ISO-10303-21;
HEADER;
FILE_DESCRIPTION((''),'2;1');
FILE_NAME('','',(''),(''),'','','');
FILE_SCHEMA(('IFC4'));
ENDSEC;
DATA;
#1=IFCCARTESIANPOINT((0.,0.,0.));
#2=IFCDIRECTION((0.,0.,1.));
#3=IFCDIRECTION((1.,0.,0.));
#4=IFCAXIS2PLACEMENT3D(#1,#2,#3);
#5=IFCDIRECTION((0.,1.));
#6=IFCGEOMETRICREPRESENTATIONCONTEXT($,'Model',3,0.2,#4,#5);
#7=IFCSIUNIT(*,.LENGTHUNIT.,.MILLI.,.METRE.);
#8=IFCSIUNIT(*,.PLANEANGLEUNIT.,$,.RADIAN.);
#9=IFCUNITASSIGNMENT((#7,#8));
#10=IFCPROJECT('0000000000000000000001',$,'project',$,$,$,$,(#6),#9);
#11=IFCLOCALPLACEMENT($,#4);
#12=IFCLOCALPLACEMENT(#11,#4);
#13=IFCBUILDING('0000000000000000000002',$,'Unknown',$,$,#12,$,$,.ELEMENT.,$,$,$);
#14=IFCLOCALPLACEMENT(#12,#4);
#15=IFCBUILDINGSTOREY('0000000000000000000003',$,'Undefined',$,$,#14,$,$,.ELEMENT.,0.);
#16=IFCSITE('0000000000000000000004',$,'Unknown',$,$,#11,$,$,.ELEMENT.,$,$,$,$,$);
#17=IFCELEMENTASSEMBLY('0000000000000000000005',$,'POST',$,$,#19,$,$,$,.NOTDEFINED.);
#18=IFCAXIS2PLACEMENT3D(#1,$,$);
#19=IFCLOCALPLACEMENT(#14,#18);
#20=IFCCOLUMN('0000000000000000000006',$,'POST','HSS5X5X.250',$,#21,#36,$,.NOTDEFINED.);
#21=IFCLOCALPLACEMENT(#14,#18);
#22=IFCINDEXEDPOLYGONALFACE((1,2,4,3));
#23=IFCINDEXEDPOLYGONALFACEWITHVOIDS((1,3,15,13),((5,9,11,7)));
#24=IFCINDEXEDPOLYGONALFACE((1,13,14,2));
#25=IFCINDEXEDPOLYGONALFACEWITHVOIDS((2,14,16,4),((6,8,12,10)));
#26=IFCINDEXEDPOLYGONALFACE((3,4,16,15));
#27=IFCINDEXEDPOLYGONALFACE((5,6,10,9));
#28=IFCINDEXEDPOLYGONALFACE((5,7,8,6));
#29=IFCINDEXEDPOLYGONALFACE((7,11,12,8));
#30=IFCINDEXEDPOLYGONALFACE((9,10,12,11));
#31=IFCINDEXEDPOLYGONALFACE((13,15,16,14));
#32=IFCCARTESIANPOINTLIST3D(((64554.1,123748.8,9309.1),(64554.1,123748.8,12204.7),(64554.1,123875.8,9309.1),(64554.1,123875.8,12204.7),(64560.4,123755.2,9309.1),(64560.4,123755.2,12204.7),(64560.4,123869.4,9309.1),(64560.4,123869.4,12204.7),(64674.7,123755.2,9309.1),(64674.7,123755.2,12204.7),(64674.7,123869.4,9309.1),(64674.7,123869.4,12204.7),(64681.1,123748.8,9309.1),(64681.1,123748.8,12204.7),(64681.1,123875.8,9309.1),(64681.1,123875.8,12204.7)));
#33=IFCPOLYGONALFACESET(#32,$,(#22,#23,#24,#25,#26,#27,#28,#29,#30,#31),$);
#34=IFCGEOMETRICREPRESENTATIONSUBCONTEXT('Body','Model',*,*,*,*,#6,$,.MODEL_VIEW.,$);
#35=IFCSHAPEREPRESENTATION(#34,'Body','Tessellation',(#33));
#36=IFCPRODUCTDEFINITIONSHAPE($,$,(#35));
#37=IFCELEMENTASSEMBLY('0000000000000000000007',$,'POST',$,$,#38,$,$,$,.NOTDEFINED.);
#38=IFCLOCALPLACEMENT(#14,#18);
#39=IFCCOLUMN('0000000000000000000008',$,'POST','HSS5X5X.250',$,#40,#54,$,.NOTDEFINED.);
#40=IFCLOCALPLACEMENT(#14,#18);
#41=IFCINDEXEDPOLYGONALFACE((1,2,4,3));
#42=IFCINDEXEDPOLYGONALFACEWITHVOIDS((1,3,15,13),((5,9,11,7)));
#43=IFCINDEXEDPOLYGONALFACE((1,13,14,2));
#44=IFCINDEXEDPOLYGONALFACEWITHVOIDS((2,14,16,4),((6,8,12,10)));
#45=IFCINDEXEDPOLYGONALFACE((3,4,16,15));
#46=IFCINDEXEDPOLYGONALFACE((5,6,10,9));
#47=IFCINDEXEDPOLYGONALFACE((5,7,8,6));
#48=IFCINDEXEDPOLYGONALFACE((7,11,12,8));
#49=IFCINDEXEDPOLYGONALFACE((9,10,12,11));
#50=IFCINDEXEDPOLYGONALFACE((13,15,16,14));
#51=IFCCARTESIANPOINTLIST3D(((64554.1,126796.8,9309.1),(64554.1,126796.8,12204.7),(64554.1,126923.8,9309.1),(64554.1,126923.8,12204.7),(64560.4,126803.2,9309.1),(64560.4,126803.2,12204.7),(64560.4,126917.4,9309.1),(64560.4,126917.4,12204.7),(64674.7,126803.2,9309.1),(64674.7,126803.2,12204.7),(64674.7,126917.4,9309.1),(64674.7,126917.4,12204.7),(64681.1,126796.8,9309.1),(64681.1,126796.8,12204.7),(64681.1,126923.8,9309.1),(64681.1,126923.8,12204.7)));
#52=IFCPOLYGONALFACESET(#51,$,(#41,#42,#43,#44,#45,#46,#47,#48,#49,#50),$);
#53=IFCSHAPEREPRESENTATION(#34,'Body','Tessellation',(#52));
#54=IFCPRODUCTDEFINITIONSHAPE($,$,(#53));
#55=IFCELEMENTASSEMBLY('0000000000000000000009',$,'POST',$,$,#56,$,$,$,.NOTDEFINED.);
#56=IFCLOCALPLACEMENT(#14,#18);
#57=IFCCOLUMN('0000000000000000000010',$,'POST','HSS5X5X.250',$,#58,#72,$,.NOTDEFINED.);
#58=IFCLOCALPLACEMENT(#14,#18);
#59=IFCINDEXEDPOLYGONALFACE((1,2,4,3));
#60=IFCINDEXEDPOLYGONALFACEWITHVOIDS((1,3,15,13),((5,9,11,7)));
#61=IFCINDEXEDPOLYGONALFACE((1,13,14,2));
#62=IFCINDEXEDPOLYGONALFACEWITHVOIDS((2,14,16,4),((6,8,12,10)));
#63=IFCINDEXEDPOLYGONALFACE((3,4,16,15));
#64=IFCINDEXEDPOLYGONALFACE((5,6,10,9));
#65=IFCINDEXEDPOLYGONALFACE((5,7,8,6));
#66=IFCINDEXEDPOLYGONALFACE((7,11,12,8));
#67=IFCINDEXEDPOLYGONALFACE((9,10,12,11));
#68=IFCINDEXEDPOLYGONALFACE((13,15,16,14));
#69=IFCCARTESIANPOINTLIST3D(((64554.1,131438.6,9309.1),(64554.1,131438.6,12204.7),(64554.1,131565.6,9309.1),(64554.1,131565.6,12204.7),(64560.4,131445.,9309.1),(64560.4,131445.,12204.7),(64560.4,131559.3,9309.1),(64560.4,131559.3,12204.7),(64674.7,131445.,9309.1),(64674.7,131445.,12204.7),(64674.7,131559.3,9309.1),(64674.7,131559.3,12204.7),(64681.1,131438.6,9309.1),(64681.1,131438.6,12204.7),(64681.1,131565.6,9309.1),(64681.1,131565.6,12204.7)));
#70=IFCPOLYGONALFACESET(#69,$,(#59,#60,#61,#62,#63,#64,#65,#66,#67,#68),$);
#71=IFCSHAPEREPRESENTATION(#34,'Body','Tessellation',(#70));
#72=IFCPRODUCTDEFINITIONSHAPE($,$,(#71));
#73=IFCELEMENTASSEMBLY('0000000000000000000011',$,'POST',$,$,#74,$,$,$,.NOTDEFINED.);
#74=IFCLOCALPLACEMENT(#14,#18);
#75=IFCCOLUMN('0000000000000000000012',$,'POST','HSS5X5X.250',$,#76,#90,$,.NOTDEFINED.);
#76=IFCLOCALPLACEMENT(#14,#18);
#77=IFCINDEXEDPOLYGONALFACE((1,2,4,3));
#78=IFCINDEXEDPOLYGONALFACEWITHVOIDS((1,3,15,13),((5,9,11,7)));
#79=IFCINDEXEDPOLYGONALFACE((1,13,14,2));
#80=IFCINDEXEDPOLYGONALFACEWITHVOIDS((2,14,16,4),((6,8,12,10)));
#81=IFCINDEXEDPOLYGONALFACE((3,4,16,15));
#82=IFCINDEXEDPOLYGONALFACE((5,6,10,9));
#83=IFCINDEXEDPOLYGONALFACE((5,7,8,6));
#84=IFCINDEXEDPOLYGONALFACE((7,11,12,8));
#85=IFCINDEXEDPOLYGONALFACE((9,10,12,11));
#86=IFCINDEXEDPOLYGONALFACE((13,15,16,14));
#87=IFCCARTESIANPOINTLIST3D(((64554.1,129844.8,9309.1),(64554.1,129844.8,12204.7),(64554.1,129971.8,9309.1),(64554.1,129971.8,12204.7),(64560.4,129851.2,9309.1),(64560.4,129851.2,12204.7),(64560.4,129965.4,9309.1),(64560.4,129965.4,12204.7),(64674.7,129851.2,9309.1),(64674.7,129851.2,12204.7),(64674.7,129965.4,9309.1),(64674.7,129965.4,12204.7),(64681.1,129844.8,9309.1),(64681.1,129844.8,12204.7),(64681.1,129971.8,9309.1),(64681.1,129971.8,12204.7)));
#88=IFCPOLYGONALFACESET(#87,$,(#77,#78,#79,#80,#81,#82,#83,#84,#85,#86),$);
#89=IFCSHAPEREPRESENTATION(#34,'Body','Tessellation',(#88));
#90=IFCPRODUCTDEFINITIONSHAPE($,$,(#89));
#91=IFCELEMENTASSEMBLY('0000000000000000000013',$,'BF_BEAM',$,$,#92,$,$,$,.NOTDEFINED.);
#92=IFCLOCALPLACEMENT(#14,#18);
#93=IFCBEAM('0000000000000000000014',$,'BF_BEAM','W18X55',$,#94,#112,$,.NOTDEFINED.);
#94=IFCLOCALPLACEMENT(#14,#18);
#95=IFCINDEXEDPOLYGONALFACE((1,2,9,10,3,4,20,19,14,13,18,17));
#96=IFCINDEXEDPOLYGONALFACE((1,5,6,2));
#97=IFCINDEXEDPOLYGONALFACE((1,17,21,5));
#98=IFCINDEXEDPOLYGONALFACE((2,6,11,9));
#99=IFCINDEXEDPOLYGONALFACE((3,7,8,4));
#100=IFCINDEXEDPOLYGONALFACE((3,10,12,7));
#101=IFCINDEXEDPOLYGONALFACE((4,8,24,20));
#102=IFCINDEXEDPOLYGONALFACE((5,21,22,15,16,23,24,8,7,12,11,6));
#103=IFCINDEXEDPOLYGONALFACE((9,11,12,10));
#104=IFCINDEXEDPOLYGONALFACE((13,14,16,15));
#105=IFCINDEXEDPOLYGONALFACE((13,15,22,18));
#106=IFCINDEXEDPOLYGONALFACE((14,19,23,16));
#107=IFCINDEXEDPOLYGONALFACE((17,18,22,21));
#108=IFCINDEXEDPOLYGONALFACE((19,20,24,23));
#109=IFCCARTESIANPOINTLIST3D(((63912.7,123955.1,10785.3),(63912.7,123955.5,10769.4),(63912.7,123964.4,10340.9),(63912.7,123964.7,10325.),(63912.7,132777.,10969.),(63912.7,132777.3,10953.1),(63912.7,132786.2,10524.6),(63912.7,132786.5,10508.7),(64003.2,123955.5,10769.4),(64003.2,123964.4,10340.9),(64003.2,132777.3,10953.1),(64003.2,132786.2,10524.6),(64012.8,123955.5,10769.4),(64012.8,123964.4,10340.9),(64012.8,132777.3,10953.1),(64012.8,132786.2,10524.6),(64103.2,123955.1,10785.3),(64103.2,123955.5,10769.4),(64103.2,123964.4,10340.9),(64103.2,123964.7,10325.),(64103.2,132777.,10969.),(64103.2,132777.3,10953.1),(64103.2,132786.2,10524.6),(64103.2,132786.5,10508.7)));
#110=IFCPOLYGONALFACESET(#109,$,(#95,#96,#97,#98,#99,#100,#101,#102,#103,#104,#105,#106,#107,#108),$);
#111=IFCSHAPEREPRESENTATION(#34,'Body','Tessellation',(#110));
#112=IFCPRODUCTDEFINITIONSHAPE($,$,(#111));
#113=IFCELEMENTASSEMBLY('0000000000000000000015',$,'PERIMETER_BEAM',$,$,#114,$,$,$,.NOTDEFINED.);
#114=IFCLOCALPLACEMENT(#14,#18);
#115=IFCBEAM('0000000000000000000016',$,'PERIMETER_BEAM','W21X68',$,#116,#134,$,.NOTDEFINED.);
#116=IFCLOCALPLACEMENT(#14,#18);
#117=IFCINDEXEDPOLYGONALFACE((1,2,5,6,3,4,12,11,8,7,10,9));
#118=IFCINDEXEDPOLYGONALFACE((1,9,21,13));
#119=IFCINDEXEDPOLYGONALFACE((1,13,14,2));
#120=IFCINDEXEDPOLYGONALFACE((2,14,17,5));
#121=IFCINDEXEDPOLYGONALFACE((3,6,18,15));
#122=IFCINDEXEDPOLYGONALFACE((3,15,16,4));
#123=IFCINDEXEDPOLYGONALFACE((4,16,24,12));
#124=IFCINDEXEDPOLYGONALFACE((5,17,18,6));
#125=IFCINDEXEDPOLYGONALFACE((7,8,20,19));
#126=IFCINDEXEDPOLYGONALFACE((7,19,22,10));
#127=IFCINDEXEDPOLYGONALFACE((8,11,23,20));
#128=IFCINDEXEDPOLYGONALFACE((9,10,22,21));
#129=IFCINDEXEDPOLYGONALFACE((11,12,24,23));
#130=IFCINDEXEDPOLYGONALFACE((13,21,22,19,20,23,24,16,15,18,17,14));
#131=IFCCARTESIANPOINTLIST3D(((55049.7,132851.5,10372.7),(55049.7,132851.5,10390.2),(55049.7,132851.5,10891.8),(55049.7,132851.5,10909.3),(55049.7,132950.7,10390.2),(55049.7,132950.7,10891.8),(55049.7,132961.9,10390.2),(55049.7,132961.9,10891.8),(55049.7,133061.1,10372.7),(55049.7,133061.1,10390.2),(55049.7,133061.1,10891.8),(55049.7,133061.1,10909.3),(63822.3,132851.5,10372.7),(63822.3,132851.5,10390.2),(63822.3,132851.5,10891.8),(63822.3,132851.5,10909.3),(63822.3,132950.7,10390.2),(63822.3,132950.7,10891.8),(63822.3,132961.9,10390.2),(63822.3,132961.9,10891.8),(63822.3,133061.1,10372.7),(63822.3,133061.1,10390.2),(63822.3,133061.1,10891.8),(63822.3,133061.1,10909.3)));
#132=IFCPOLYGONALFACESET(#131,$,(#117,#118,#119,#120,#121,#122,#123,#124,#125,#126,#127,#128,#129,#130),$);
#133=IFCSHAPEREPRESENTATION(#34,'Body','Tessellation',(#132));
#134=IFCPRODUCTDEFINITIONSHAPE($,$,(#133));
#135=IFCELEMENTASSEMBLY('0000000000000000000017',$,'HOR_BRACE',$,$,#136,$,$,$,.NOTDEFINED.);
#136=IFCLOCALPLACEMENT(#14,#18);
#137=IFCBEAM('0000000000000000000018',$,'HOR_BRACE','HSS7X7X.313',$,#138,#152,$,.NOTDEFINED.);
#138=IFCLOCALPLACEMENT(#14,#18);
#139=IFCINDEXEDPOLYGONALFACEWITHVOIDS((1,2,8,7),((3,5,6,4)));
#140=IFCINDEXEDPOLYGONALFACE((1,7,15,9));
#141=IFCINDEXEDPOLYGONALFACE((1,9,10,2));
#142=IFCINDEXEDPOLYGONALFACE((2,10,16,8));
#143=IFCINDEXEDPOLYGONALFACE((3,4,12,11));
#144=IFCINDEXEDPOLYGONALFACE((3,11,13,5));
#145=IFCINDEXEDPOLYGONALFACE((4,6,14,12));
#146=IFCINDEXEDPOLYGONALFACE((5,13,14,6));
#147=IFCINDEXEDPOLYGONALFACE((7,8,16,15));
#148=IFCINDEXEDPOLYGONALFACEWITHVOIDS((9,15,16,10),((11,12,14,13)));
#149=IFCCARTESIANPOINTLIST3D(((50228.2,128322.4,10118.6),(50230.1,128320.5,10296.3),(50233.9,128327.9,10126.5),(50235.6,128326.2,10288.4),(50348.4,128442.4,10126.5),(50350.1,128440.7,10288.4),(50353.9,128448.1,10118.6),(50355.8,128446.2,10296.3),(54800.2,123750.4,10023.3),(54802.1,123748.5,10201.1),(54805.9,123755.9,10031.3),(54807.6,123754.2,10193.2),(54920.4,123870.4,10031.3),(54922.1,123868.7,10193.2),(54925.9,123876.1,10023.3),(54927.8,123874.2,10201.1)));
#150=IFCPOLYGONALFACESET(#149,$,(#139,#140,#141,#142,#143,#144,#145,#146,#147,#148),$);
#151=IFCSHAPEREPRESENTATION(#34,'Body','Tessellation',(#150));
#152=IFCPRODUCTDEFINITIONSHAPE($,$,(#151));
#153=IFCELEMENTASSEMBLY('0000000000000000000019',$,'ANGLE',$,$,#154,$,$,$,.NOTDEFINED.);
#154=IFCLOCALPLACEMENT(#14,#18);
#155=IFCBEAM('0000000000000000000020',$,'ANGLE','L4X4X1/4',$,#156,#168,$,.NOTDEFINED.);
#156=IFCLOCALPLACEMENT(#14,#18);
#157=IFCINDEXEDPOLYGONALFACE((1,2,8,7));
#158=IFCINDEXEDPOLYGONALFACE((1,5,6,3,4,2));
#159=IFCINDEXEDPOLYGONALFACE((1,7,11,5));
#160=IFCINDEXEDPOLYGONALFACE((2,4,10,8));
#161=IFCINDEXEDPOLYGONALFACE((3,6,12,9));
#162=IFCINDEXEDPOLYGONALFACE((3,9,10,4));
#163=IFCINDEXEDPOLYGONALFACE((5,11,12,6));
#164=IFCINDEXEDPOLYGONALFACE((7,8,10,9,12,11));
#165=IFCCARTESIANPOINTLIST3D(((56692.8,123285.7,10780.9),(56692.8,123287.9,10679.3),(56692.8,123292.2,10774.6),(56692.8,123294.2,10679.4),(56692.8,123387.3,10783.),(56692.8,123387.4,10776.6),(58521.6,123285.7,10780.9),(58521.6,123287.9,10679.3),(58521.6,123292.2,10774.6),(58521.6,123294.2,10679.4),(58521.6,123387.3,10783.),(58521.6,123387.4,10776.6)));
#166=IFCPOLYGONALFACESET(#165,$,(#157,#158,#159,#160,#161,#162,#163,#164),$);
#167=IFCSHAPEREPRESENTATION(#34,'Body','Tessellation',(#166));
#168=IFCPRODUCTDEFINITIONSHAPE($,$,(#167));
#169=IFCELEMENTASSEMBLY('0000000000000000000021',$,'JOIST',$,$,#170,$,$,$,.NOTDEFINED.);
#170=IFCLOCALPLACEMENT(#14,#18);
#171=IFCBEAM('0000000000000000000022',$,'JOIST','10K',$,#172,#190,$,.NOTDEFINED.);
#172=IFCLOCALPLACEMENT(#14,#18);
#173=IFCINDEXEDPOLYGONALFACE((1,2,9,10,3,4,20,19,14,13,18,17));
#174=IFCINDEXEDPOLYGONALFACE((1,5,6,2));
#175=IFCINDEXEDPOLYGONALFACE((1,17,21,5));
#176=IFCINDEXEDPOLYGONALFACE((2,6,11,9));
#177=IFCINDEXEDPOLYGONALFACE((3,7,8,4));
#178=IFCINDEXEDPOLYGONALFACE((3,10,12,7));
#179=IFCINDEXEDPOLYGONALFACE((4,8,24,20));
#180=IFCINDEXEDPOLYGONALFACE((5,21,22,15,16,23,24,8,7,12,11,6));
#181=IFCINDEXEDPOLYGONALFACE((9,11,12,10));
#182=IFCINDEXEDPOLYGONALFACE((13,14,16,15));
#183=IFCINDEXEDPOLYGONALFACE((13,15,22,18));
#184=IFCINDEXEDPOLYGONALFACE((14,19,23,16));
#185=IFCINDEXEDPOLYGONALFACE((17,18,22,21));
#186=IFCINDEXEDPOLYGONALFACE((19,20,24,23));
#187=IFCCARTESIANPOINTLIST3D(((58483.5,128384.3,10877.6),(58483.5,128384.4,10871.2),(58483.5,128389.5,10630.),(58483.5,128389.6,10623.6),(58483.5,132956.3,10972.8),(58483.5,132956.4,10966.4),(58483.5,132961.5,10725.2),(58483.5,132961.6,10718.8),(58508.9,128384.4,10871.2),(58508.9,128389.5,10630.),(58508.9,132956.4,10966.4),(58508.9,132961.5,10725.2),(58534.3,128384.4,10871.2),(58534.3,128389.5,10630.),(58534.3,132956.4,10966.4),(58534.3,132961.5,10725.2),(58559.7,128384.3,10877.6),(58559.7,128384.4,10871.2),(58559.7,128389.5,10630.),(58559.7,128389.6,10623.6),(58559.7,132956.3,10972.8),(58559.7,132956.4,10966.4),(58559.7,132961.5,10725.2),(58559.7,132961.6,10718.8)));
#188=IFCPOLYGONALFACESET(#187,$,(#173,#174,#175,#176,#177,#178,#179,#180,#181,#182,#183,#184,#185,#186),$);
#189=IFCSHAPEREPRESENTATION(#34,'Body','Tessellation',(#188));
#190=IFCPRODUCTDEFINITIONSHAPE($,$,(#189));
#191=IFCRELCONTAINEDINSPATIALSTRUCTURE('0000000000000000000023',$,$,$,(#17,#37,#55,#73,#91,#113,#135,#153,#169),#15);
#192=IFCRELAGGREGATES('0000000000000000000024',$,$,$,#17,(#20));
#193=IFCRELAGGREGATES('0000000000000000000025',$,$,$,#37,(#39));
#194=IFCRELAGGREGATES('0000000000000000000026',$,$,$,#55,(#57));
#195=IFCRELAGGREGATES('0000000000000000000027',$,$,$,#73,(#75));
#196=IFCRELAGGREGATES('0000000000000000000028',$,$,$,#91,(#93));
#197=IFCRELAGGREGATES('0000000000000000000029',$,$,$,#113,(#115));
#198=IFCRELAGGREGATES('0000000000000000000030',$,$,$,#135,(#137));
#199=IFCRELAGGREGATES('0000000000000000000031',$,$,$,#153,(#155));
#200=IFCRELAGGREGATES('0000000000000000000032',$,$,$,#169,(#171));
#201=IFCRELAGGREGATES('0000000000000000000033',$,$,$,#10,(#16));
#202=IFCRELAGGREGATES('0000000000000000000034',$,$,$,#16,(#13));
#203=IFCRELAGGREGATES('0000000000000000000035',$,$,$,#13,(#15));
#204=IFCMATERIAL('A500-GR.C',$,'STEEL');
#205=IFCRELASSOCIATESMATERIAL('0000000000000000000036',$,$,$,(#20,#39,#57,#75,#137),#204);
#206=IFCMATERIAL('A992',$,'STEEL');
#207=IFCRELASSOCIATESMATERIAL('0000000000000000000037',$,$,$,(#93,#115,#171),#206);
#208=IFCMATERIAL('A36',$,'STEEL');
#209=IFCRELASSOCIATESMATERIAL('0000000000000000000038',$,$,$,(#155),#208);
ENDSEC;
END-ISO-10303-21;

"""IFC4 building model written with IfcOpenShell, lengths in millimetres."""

from ifc_helpers import new_model, si_unit, direction, frame, origin_with_axes, place, context, subcontext, project, spatial, line, indexed_curve, outline, extrude, material, element, aggregate, save


model = new_model("IFC4")

# Units and contexts
model_context = context("Model", 3, precision=0.2, world=origin_with_axes(), true_north=direction((0.0, 1.0)))
body_context = subcontext(model_context, "Body", "Model", "MODEL_VIEW")
ifc_project = project(units=[si_unit("LENGTHUNIT", "METRE", prefix="MILLI"), si_unit("PLANEANGLEUNIT", "RADIAN")], contexts=[model_context])

# Site, building, storey
site_placement = place(None, origin_with_axes())
site = spatial("IfcSite", under=ifc_project, at=site_placement, Name="Unknown", CompositionType="ELEMENT")
building_placement = place(site_placement, origin_with_axes())
building = spatial("IfcBuilding", under=site, at=building_placement, Name="Unknown", CompositionType="ELEMENT")
storey_placement = place(building_placement, origin_with_axes())
storey = spatial("IfcBuildingStorey", under=building, at=storey_placement, Name="Undefined", CompositionType="ELEMENT", Elevation=0.0)

# Element assemblies, columns
assembly_1_placement = place(storey_placement, frame((64617.6, 123812.3, 9309.1), z_axis=(0.0, -1.0, 0.0), x_axis=(0.0, 0.0, 1.0)))
assembly_1 = element("IfcElementAssembly", 1, at=assembly_1_placement, inside=storey, Name="POST", PredefinedType="NOTDEFINED")
ifc_material_1 = material(Name="A500-GR.C", Category="STEEL")
column_1_placement = place(assembly_1_placement, origin_with_axes())
column_1 = element("IfcColumn", 2, at=column_1_placement, material=ifc_material_1, Name="POST", Description="HSS5X5X.250", PredefinedType="NOTDEFINED", context=body_context, shape_type="SolidModel", body=[
    extrude(outline(indexed_curve([(-63.5, -63.5), (63.5, -63.5), (63.5, 63.5), (-63.5, 63.5)], segments=[line(1, 2, 3, 4, 1)]), holes=[indexed_curve([(-57.1, -57.1), (-57.1, 57.1), (57.1, 57.1), (57.1, -57.1)], segments=[line(1, 2, 3, 4, 1)])]), frame((0.0, 0.0, 0.0), z_axis=(-1.0, 0.0, 0.0), x_axis=(0.0, 0.0, 1.0)), (0.0, 0.0, -1.0), 2895.6),
])
aggregate(assembly_1, [column_1])
assembly_2_placement = place(storey_placement, frame((64617.6, 126860.3, 9309.1), z_axis=(0.0, -1.0, 0.0), x_axis=(0.0, 0.0, 1.0)))
assembly_2 = element("IfcElementAssembly", 3, at=assembly_2_placement, inside=storey, Name="POST", PredefinedType="NOTDEFINED")
column_2_placement = place(assembly_2_placement, origin_with_axes())
column_2 = element("IfcColumn", 4, at=column_2_placement, material=ifc_material_1, Name="POST", Description="HSS5X5X.250", PredefinedType="NOTDEFINED", context=body_context, shape_type="SolidModel", body=[
    extrude(outline(indexed_curve([(-63.5, -63.5), (63.5, -63.5), (63.5, 63.5), (-63.5, 63.5)], segments=[line(1, 2, 3, 4, 1)]), holes=[indexed_curve([(-57.1, -57.1), (-57.1, 57.1), (57.1, 57.1), (57.1, -57.1)], segments=[line(1, 2, 3, 4, 1)])]), frame((0.0, 0.0, 0.0), z_axis=(-1.0, 0.0, 0.0), x_axis=(0.0, 0.0, 1.0)), (0.0, 0.0, -1.0), 2895.6),
])
aggregate(assembly_2, [column_2])
assembly_3_placement = place(storey_placement, frame((64617.6, 131502.1, 9309.1), z_axis=(0.0, -1.0, 0.0), x_axis=(0.0, 0.0, 1.0)))
assembly_3 = element("IfcElementAssembly", 5, at=assembly_3_placement, inside=storey, Name="POST", PredefinedType="NOTDEFINED")
column_3_placement = place(assembly_3_placement, origin_with_axes())
column_3 = element("IfcColumn", 6, at=column_3_placement, material=ifc_material_1, Name="POST", Description="HSS5X5X.250", PredefinedType="NOTDEFINED", context=body_context, shape_type="SolidModel", body=[
    extrude(outline(indexed_curve([(-63.5, -63.5), (63.5, -63.5), (63.5, 63.5), (-63.5, 63.5)], segments=[line(1, 2, 3, 4, 1)]), holes=[indexed_curve([(-57.1, -57.1), (-57.1, 57.1), (57.1, 57.1), (57.1, -57.1)], segments=[line(1, 2, 3, 4, 1)])]), frame((0.0, 0.0, 0.0), z_axis=(-1.0, 0.0, 0.0), x_axis=(0.0, 0.0, 1.0)), (0.0, 0.0, -1.0), 2895.6),
])
aggregate(assembly_3, [column_3])
assembly_4_placement = place(storey_placement, frame((64617.6, 129908.3, 9309.1), z_axis=(0.0, -1.0, 0.0), x_axis=(0.0, 0.0, 1.0)))
assembly_4 = element("IfcElementAssembly", 7, at=assembly_4_placement, inside=storey, Name="POST", PredefinedType="NOTDEFINED")
column_4_placement = place(assembly_4_placement, origin_with_axes())
column_4 = element("IfcColumn", 8, at=column_4_placement, material=ifc_material_1, Name="POST", Description="HSS5X5X.250", PredefinedType="NOTDEFINED", context=body_context, shape_type="SolidModel", body=[
    extrude(outline(indexed_curve([(-63.5, -63.5), (63.5, -63.5), (63.5, 63.5), (-63.5, 63.5)], segments=[line(1, 2, 3, 4, 1)]), holes=[indexed_curve([(-57.1, -57.1), (-57.1, 57.1), (57.1, 57.1), (57.1, -57.1)], segments=[line(1, 2, 3, 4, 1)])]), frame((0.0, 0.0, 0.0), z_axis=(-1.0, 0.0, 0.0), x_axis=(0.0, 0.0, 1.0)), (0.0, 0.0, -1.0), 2895.6),
])
aggregate(assembly_4, [column_4])

# Element assembly, beam
assembly_5_placement = place(storey_placement, frame((64008.0, 123959.9, 10555.1), z_axis=(1.0, 0.0, 0.0), x_axis=(0.0, 0.999783, 0.020819)))
assembly_5 = element("IfcElementAssembly", 9, at=assembly_5_placement, inside=storey, Name="BF_BEAM", PredefinedType="NOTDEFINED")
ifc_material_2 = material(Name="A992", Category="STEEL")
beam_1_placement = place(assembly_5_placement, origin_with_axes())
beam_1 = element("IfcBeam", 10, at=beam_1_placement, material=ifc_material_2, Name="BF_BEAM", Description="W18X55", PredefinedType="NOTDEFINED", context=body_context, shape_type="SolidModel", body=[
    extrude(outline(indexed_curve([(-95.2, -230.2), (95.2, -230.2), (95.2, -214.3), (4.8, -214.3), (4.8, 214.3), (95.2, 214.3), (95.2, 230.2), (-95.2, 230.2), (-95.2, 214.3), (-4.8, 214.3), (-4.8, -214.3), (-95.2, -214.3)], segments=[line(1, 2, 3, 4, 5, 6, 7, 8, 9, 10, 11, 12, 1)])), frame((0.0, 0.0, 0.0), z_axis=(-1.0, 0.0, 0.0), x_axis=(0.0, 0.0, 1.0)), (0.0, 0.0, -1.0), 8823.7),
])
aggregate(assembly_5, [beam_1])

# Element assemblies, beams
assembly_6_placement = place(storey_placement, frame((55049.7, 132956.3, 10641.0), z_axis=(0.0, -1.0, 0.0), x_axis=(1.0, 0.0, 0.0)))
assembly_6 = element("IfcElementAssembly", 11, at=assembly_6_placement, inside=storey, Name="PERIMETER_BEAM", PredefinedType="NOTDEFINED")
beam_2_placement = place(assembly_6_placement, origin_with_axes())
beam_2 = element("IfcBeam", 12, at=beam_2_placement, material=ifc_material_2, Name="PERIMETER_BEAM", Description="W21X68", PredefinedType="NOTDEFINED", context=body_context, shape_type="SolidModel", body=[
    extrude(outline(indexed_curve([(-104.8, -268.3), (104.8, -268.3), (104.8, -250.8), (5.6, -250.8), (5.6, 250.8), (104.8, 250.8), (104.8, 268.3), (-104.8, 268.3), (-104.8, 250.8), (-5.6, 250.8), (-5.6, -250.8), (-104.8, -250.8)], segments=[line(1, 2, 3, 4, 5, 6, 7, 8, 9, 10, 11, 12, 1)])), frame((0.0, 0.0, 0.0), z_axis=(-1.0, 0.0, 0.0), x_axis=(0.0, 0.0, 1.0)), (0.0, 0.0, -1.0), 8772.5),
])
aggregate(assembly_6, [beam_2])
assembly_7_placement = place(storey_placement, frame((54864.0, 123812.3, 10112.2), z_axis=(0.707107, 0.707107, 0.0), x_axis=(-0.70703, 0.70703, 0.01473)))
assembly_7 = element("IfcElementAssembly", 13, at=assembly_7_placement, inside=storey, Name="HOR_BRACE", PredefinedType="NOTDEFINED")
beam_3_placement = place(assembly_7_placement, origin_with_axes())
beam_3 = element("IfcBeam", 14, at=beam_3_placement, material=ifc_material_1, Name="HOR_BRACE", Description="HSS7X7X.313", PredefinedType="NOTDEFINED", context=body_context, shape_type="SolidModel", body=[
    extrude(outline(indexed_curve([(-88.9, -88.9), (88.9, -88.9), (88.9, 88.9), (-88.9, 88.9)], segments=[line(1, 2, 3, 4, 1)]), holes=[indexed_curve([(-81.0, -81.0), (-81.0, 81.0), (81.0, 81.0), (81.0, -81.0)], segments=[line(1, 2, 3, 4, 1)])]), frame((0.0, 0.0, 0.0), z_axis=(-1.0, 0.0, 0.0), x_axis=(0.0, 0.0, 1.0)), (0.0, 0.0, -1.0), 6466.5),
])
aggregate(assembly_7, [beam_3])
assembly_8_placement = place(storey_placement, frame((56692.8, 123337.6, 10731.1), z_axis=(0.0, 0.999783, 0.020819), x_axis=(1.0, 0.0, 0.0)))
assembly_8 = element("IfcElementAssembly", 15, at=assembly_8_placement, inside=storey, Name="ANGLE", PredefinedType="NOTDEFINED")
ifc_material_3 = material(Name="A36", Category="STEEL")
beam_4_placement = place(assembly_8_placement, origin_with_axes())
beam_4 = element("IfcBeam", 16, at=beam_4_placement, material=ifc_material_3, Name="ANGLE", Description="L4X4X1/4", PredefinedType="NOTDEFINED", context=body_context, shape_type="SolidModel", body=[
    extrude(outline(indexed_curve([(-50.8, -50.8), (50.8, -50.8), (50.8, -44.5), (-44.5, -44.5), (-44.5, 50.8), (-50.8, 50.8)], segments=[line(1, 2, 3, 4, 5, 6, 1)])), frame((0.0, 0.0, 0.0), z_axis=(-1.0, 0.0, 0.0), x_axis=(0.0, 0.0, 1.0)), (0.0, 0.0, -1.0), 1828.8),
])
aggregate(assembly_8, [beam_4])
assembly_9_placement = place(storey_placement, frame((58521.6, 128386.9, 10750.6), z_axis=(1.0, 0.0, 0.0), x_axis=(0.0, 0.999783, 0.020819)))
assembly_9 = element("IfcElementAssembly", 17, at=assembly_9_placement, inside=storey, Name="JOIST", PredefinedType="NOTDEFINED")
beam_5_placement = place(assembly_9_placement, origin_with_axes())
beam_5 = element("IfcBeam", 18, at=beam_5_placement, material=ifc_material_2, Name="JOIST", Description="10K", PredefinedType="NOTDEFINED", context=body_context, shape_type="SolidModel", body=[
    extrude(outline(indexed_curve([(-38.1, -127.0), (38.1, -127.0), (38.1, -120.7), (12.7, -120.7), (12.7, 120.7), (38.1, 120.7), (38.1, 127.0), (-38.1, 127.0), (-38.1, 120.7), (-12.7, 120.7), (-12.7, -120.7), (-38.1, -120.7)], segments=[line(1, 2, 3, 4, 5, 6, 7, 8, 9, 10, 11, 12, 1)])), frame((0.0, 0.0, 0.0), z_axis=(-1.0, 0.0, 0.0), x_axis=(0.0, 0.0, 1.0)), (0.0, 0.0, -1.0), 4573.0),
])
aggregate(assembly_9, [beam_5])

save(model, "model.ifc")
